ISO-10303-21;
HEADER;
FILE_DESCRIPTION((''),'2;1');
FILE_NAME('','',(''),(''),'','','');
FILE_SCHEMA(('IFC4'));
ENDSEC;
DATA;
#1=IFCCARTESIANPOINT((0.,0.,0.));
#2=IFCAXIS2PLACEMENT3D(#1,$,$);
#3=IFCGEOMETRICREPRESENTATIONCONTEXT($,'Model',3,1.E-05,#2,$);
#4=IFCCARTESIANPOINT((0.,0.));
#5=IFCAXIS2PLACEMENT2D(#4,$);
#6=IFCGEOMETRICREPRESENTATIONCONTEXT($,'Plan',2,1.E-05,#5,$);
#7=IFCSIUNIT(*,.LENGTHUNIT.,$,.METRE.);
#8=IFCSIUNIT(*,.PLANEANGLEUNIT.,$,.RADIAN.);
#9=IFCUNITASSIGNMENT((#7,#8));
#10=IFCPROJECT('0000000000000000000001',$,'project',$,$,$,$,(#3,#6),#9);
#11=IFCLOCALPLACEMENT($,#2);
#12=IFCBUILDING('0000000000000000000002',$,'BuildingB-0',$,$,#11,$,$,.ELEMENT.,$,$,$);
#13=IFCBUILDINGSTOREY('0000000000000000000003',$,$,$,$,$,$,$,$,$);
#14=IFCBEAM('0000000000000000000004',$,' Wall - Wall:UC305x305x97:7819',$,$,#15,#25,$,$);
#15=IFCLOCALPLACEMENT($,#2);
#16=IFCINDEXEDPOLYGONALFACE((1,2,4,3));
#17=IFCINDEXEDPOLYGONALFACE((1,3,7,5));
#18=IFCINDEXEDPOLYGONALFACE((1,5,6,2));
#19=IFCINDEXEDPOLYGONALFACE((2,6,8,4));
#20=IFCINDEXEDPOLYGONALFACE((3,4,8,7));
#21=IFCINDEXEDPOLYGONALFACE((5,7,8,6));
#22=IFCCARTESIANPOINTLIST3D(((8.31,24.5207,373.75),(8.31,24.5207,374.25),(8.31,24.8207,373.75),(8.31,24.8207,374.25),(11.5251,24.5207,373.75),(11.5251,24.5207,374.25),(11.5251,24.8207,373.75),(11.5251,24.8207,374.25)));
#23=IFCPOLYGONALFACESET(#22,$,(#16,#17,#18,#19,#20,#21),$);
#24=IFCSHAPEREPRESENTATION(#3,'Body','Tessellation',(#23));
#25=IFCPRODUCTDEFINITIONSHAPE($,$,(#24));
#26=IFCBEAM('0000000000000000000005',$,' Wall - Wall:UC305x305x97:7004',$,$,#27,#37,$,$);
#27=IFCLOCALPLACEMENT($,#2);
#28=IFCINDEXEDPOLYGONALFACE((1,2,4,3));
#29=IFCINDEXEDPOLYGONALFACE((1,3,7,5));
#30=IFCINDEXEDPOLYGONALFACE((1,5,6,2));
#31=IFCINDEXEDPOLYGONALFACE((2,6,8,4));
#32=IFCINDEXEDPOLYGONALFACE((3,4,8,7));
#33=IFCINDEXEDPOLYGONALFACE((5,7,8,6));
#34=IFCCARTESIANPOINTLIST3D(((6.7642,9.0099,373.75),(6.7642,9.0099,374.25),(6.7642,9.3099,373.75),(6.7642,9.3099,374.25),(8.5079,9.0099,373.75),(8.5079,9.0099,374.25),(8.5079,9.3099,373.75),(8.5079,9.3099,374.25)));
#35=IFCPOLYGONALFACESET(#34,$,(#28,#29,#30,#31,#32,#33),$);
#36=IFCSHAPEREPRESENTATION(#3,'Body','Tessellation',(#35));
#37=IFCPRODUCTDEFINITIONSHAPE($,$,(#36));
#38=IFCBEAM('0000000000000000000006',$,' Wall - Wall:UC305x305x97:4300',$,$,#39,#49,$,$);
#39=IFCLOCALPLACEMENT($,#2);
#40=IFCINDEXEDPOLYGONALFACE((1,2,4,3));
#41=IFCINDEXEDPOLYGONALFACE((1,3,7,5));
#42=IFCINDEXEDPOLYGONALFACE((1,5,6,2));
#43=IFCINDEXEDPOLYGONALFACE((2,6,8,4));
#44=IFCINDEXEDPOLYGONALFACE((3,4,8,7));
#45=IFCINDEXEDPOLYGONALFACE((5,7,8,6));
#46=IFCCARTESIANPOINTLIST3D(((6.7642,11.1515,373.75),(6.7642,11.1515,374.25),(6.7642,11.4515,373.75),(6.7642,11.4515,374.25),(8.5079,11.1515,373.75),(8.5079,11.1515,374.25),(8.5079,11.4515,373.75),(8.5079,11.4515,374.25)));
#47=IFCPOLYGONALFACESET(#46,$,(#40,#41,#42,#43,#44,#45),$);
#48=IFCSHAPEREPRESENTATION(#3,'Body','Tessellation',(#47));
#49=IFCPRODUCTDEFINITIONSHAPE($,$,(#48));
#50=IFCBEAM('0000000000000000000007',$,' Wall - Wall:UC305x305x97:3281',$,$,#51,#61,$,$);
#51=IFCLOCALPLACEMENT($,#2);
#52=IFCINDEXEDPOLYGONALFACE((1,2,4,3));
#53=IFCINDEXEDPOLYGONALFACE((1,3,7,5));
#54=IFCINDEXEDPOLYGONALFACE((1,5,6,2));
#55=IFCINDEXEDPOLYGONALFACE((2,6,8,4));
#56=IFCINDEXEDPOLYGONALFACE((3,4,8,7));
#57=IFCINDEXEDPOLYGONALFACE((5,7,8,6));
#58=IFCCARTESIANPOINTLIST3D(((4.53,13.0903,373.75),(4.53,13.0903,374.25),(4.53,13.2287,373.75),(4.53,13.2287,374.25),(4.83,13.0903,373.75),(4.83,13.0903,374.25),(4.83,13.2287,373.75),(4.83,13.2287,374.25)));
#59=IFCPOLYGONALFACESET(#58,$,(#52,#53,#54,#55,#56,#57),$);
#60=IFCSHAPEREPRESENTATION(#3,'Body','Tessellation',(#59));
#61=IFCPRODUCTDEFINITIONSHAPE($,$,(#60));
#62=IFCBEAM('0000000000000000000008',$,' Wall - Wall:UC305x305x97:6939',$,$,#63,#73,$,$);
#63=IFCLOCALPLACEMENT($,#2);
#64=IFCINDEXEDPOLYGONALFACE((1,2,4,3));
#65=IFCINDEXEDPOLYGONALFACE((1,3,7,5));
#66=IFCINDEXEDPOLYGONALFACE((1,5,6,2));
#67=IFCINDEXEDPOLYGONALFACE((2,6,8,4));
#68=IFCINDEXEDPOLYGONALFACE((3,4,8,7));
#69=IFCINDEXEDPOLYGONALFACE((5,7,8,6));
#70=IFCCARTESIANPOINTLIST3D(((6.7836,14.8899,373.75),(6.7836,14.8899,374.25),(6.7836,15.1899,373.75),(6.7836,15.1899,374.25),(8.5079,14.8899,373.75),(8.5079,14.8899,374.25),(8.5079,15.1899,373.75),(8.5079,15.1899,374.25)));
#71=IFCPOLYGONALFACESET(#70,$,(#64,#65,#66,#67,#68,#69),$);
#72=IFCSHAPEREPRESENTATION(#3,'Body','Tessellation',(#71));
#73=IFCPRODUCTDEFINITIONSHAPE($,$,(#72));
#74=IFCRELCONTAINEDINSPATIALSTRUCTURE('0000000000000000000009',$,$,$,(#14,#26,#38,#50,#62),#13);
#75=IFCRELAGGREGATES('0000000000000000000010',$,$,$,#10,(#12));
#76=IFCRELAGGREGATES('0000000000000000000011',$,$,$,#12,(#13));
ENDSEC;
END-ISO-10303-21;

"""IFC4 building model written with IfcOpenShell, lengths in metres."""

from ifc_helpers import new_model, si_unit, origin, origin_2d, place, context, project, spatial, polyline, outline, extrude, element, save


model = new_model("IFC4")

# Units and contexts
model_context = context("Model", 3, precision=1e-05, world=origin())
plan_context = context("Plan", 2, precision=1e-05, world=origin_2d())
ifc_project = project(units=[si_unit("LENGTHUNIT", "METRE"), si_unit("PLANEANGLEUNIT", "RADIAN")], contexts=[model_context, plan_context])

# Building, storey
building_placement = place(None, origin())
building = spatial("IfcBuilding", under=ifc_project, at=building_placement, Name="BuildingB-0", CompositionType="ELEMENT")
storey = spatial("IfcBuildingStorey", under=building)

# Beams
element("IfcBeam", 1, inside=storey, Name=" Wall - Wall:UC305x305x97:7819", context=model_context, shape_type="SweptSolid", body=[
    extrude(outline(polyline([(8.31, 24.5207, 373.75), (8.31, 24.8207, 373.75), (11.5251, 24.8207, 373.75), (11.5251, 24.5207, 373.75), (8.31, 24.5207, 373.75)])), None, (0.0, 0.0, 1.0), 0.5),
])
element("IfcBeam", 2, inside=storey, Name=" Wall - Wall:UC305x305x97:7004", context=model_context, shape_type="SweptSolid", body=[
    extrude(outline(polyline([(6.7642, 9.0099, 373.75), (6.7642, 9.3099, 373.75), (8.5079, 9.3099, 373.75), (8.5079, 9.0099, 373.75), (6.7642, 9.0099, 373.75)])), None, (0.0, 0.0, 1.0), 0.5),
])
element("IfcBeam", 3, inside=storey, Name=" Wall - Wall:UC305x305x97:4300", context=model_context, shape_type="SweptSolid", body=[
    extrude(outline(polyline([(6.7642, 11.1515, 373.75), (6.7642, 11.4515, 373.75), (8.5079, 11.4515, 373.75), (8.5079, 11.1515, 373.75), (6.7642, 11.1515, 373.75)])), None, (0.0, 0.0, 1.0), 0.5),
])
element("IfcBeam", 4, inside=storey, Name=" Wall - Wall:UC305x305x97:3281", context=model_context, shape_type="SweptSolid", body=[
    extrude(outline(polyline([(4.53, 13.0903, 373.75), (4.53, 13.2287, 373.75), (4.83, 13.2287, 373.75), (4.83, 13.0903, 373.75), (4.53, 13.0903, 373.75)])), None, (0.0, 0.0, 1.0), 0.5),
])
element("IfcBeam", 5, inside=storey, Name=" Wall - Wall:UC305x305x97:6939", context=model_context, shape_type="SweptSolid", body=[
    extrude(outline(polyline([(6.7836, 14.8899, 373.75), (6.7836, 15.1899, 373.75), (8.5079, 15.1899, 373.75), (8.5079, 14.8899, 373.75), (6.7836, 14.8899, 373.75)])), None, (0.0, 0.0, 1.0), 0.5),
])

save(model, "model.ifc")
